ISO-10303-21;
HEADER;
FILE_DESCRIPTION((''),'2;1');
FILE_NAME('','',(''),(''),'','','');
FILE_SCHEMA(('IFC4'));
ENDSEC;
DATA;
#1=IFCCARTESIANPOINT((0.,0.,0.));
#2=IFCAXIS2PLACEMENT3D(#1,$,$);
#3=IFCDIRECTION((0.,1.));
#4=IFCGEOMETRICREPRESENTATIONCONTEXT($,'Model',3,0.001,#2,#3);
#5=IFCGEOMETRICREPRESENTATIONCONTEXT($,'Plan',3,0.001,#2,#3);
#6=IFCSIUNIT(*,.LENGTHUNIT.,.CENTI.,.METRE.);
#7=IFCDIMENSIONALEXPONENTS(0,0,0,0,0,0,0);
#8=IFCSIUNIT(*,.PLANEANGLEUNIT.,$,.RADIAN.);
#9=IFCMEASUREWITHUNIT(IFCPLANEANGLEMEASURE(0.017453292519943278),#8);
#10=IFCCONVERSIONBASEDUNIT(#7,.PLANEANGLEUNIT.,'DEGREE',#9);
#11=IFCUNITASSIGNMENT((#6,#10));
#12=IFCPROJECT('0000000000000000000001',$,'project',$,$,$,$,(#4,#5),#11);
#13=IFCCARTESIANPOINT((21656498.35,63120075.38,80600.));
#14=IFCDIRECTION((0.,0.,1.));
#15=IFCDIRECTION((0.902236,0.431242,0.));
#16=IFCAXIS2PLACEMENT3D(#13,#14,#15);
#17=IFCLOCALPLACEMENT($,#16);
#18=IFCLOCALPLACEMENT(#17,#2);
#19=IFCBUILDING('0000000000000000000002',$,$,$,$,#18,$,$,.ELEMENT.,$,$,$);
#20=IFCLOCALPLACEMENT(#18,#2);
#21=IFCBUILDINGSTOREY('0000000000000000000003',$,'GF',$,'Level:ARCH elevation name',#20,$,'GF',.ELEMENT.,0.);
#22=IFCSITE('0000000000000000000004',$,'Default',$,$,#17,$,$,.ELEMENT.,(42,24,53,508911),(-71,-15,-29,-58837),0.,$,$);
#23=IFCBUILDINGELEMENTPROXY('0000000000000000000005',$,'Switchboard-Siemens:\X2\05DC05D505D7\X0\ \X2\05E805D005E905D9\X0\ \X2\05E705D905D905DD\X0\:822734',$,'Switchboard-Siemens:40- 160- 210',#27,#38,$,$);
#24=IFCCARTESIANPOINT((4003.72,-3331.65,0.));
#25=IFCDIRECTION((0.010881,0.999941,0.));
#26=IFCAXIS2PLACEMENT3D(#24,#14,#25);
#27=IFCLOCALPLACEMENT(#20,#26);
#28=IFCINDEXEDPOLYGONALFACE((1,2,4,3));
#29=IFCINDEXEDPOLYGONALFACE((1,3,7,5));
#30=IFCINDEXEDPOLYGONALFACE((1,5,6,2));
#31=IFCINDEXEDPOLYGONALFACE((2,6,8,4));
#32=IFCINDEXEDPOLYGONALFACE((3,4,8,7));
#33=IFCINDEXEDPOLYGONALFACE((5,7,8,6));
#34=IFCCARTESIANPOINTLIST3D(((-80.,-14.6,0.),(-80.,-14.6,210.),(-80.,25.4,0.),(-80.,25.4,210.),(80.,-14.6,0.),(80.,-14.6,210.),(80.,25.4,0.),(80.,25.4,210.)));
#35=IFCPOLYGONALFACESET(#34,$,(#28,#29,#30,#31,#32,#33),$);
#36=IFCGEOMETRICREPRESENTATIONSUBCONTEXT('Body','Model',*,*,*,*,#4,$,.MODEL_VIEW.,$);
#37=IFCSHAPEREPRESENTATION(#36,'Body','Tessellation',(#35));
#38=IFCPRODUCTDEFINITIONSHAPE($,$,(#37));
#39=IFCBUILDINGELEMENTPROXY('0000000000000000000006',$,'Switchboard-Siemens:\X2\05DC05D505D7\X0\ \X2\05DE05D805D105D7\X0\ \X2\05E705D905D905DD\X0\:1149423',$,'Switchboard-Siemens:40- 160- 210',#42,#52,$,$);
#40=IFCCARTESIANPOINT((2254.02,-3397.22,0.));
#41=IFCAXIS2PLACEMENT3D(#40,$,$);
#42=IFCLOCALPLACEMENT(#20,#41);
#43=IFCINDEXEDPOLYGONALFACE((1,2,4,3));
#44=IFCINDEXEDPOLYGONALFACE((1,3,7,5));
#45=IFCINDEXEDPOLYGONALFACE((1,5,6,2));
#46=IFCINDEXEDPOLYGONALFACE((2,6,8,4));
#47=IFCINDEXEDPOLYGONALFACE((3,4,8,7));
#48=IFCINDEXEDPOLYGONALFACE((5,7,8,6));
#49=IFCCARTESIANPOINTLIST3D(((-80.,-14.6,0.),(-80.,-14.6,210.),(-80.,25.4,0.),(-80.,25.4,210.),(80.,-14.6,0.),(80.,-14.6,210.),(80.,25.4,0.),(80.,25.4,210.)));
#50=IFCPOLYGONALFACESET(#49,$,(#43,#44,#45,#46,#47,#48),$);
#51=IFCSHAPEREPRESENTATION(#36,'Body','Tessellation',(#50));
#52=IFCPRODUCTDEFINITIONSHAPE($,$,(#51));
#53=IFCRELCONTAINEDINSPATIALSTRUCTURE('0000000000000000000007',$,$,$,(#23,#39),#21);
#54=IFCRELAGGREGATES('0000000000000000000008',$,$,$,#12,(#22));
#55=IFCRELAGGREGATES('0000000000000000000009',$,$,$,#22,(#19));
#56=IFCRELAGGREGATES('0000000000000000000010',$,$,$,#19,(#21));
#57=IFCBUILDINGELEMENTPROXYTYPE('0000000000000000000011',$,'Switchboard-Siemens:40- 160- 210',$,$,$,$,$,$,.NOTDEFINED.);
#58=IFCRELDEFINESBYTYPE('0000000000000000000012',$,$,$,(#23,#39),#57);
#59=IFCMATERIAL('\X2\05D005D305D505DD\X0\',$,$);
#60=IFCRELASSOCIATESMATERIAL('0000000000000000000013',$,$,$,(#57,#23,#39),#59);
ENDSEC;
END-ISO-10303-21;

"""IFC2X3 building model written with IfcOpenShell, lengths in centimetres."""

from ifc_helpers import new_model, entity, si_unit, converted_unit, direction, frame, origin, origin_2d_with_axis, place, context, subcontext, project, spatial, rectangle, extrude, source, transform, mapped, material, type_object, type_shapes, element, save


model = new_model("IFC2X3")

# Units and contexts
model_context = context("Model", 3, precision=0.001, world=origin(), true_north=direction((0.0, 1.0)))
plan_context = context("Plan", 3, precision=0.001, world=origin(), true_north=direction((0.0, 1.0)))
body_context = subcontext(model_context, "Body", "Model", "MODEL_VIEW")
ifc_project = project(units=[si_unit("LENGTHUNIT", "METRE", prefix="CENTI"), converted_unit("PLANEANGLEUNIT", "DEGREE", entity("IfcPlaneAngleMeasure", 0.017453292519943278), si_unit("PLANEANGLEUNIT", "RADIAN"), dimensions=[0, 0, 0, 0, 0, 0, 0])], contexts=[model_context, plan_context])

# Site, building, storey
site_placement = place(None, frame((21656498.35, 63120075.38, 80600.0), z_axis=(0.0, 0.0, 1.0), x_axis=(0.902236, 0.431242, 0.0)))
site = spatial("IfcSite", under=ifc_project, at=site_placement, Name="Default", CompositionType="ELEMENT", RefLatitude=(42, 24, 53, 508911), RefLongitude=(-71, -15, -29, -58837), RefElevation=0.0)
building_placement = place(site_placement, origin())
building = spatial("IfcBuilding", under=site, at=building_placement, CompositionType="ELEMENT")
storey_placement = place(building_placement, origin())
storey = spatial("IfcBuildingStorey", under=building, at=storey_placement, Name="GF", ObjectType="Level:ARCH elevation name", LongName="GF", CompositionType="ELEMENT", Elevation=0.0)

# Building element proxies
ifc_material_1 = material(Name="אדום")
building_element_proxy_type_1 = type_object("IfcBuildingElementProxyType", Name="Switchboard-Siemens:40- 160- 210", PredefinedType="NOTDEFINED", material=ifc_material_1)
shared_shape_1 = source(origin(), body_context, "Body", "SweptSolid", [
    extrude(rectangle(XDim=160.0, YDim=40.0, at=origin_2d_with_axis()), frame((0.0, 5.4, 0.0), z_axis=(0.0, 0.0, 1.0), x_axis=(-1.0, 0.0, 0.0)), (0.0, 0.0, 1.0), 210.0),
])
type_shapes(building_element_proxy_type_1, [shared_shape_1])
proxy_1_placement = place(storey_placement, frame((4003.72, -3331.65, 0.0), z_axis=(0.0, 0.0, 1.0), x_axis=(0.010881, 0.999941, 0.0)))
element("IfcBuildingElementProxy", 1, at=proxy_1_placement, inside=storey, type_object=building_element_proxy_type_1, material=ifc_material_1, Name="Switchboard-Siemens:לוח ראשי קיים:822734", ObjectType="Switchboard-Siemens:40- 160- 210", context=body_context, shape_type="MappedRepresentation", body=[
    mapped(shared_shape_1, transform((0.0, 0.0, 0.0), scale=1.0)),
])
proxy_2_placement = place(storey_placement, frame((2254.02, -3397.22, 0.0)))
element("IfcBuildingElementProxy", 2, at=proxy_2_placement, inside=storey, type_object=building_element_proxy_type_1, material=ifc_material_1, Name="Switchboard-Siemens:לוח מטבח קיים:1149423", ObjectType="Switchboard-Siemens:40- 160- 210", context=body_context, shape_type="MappedRepresentation", body=[
    mapped(shared_shape_1, transform((0.0, 0.0, 0.0), scale=1.0)),
])

save(model, "model.ifc")
